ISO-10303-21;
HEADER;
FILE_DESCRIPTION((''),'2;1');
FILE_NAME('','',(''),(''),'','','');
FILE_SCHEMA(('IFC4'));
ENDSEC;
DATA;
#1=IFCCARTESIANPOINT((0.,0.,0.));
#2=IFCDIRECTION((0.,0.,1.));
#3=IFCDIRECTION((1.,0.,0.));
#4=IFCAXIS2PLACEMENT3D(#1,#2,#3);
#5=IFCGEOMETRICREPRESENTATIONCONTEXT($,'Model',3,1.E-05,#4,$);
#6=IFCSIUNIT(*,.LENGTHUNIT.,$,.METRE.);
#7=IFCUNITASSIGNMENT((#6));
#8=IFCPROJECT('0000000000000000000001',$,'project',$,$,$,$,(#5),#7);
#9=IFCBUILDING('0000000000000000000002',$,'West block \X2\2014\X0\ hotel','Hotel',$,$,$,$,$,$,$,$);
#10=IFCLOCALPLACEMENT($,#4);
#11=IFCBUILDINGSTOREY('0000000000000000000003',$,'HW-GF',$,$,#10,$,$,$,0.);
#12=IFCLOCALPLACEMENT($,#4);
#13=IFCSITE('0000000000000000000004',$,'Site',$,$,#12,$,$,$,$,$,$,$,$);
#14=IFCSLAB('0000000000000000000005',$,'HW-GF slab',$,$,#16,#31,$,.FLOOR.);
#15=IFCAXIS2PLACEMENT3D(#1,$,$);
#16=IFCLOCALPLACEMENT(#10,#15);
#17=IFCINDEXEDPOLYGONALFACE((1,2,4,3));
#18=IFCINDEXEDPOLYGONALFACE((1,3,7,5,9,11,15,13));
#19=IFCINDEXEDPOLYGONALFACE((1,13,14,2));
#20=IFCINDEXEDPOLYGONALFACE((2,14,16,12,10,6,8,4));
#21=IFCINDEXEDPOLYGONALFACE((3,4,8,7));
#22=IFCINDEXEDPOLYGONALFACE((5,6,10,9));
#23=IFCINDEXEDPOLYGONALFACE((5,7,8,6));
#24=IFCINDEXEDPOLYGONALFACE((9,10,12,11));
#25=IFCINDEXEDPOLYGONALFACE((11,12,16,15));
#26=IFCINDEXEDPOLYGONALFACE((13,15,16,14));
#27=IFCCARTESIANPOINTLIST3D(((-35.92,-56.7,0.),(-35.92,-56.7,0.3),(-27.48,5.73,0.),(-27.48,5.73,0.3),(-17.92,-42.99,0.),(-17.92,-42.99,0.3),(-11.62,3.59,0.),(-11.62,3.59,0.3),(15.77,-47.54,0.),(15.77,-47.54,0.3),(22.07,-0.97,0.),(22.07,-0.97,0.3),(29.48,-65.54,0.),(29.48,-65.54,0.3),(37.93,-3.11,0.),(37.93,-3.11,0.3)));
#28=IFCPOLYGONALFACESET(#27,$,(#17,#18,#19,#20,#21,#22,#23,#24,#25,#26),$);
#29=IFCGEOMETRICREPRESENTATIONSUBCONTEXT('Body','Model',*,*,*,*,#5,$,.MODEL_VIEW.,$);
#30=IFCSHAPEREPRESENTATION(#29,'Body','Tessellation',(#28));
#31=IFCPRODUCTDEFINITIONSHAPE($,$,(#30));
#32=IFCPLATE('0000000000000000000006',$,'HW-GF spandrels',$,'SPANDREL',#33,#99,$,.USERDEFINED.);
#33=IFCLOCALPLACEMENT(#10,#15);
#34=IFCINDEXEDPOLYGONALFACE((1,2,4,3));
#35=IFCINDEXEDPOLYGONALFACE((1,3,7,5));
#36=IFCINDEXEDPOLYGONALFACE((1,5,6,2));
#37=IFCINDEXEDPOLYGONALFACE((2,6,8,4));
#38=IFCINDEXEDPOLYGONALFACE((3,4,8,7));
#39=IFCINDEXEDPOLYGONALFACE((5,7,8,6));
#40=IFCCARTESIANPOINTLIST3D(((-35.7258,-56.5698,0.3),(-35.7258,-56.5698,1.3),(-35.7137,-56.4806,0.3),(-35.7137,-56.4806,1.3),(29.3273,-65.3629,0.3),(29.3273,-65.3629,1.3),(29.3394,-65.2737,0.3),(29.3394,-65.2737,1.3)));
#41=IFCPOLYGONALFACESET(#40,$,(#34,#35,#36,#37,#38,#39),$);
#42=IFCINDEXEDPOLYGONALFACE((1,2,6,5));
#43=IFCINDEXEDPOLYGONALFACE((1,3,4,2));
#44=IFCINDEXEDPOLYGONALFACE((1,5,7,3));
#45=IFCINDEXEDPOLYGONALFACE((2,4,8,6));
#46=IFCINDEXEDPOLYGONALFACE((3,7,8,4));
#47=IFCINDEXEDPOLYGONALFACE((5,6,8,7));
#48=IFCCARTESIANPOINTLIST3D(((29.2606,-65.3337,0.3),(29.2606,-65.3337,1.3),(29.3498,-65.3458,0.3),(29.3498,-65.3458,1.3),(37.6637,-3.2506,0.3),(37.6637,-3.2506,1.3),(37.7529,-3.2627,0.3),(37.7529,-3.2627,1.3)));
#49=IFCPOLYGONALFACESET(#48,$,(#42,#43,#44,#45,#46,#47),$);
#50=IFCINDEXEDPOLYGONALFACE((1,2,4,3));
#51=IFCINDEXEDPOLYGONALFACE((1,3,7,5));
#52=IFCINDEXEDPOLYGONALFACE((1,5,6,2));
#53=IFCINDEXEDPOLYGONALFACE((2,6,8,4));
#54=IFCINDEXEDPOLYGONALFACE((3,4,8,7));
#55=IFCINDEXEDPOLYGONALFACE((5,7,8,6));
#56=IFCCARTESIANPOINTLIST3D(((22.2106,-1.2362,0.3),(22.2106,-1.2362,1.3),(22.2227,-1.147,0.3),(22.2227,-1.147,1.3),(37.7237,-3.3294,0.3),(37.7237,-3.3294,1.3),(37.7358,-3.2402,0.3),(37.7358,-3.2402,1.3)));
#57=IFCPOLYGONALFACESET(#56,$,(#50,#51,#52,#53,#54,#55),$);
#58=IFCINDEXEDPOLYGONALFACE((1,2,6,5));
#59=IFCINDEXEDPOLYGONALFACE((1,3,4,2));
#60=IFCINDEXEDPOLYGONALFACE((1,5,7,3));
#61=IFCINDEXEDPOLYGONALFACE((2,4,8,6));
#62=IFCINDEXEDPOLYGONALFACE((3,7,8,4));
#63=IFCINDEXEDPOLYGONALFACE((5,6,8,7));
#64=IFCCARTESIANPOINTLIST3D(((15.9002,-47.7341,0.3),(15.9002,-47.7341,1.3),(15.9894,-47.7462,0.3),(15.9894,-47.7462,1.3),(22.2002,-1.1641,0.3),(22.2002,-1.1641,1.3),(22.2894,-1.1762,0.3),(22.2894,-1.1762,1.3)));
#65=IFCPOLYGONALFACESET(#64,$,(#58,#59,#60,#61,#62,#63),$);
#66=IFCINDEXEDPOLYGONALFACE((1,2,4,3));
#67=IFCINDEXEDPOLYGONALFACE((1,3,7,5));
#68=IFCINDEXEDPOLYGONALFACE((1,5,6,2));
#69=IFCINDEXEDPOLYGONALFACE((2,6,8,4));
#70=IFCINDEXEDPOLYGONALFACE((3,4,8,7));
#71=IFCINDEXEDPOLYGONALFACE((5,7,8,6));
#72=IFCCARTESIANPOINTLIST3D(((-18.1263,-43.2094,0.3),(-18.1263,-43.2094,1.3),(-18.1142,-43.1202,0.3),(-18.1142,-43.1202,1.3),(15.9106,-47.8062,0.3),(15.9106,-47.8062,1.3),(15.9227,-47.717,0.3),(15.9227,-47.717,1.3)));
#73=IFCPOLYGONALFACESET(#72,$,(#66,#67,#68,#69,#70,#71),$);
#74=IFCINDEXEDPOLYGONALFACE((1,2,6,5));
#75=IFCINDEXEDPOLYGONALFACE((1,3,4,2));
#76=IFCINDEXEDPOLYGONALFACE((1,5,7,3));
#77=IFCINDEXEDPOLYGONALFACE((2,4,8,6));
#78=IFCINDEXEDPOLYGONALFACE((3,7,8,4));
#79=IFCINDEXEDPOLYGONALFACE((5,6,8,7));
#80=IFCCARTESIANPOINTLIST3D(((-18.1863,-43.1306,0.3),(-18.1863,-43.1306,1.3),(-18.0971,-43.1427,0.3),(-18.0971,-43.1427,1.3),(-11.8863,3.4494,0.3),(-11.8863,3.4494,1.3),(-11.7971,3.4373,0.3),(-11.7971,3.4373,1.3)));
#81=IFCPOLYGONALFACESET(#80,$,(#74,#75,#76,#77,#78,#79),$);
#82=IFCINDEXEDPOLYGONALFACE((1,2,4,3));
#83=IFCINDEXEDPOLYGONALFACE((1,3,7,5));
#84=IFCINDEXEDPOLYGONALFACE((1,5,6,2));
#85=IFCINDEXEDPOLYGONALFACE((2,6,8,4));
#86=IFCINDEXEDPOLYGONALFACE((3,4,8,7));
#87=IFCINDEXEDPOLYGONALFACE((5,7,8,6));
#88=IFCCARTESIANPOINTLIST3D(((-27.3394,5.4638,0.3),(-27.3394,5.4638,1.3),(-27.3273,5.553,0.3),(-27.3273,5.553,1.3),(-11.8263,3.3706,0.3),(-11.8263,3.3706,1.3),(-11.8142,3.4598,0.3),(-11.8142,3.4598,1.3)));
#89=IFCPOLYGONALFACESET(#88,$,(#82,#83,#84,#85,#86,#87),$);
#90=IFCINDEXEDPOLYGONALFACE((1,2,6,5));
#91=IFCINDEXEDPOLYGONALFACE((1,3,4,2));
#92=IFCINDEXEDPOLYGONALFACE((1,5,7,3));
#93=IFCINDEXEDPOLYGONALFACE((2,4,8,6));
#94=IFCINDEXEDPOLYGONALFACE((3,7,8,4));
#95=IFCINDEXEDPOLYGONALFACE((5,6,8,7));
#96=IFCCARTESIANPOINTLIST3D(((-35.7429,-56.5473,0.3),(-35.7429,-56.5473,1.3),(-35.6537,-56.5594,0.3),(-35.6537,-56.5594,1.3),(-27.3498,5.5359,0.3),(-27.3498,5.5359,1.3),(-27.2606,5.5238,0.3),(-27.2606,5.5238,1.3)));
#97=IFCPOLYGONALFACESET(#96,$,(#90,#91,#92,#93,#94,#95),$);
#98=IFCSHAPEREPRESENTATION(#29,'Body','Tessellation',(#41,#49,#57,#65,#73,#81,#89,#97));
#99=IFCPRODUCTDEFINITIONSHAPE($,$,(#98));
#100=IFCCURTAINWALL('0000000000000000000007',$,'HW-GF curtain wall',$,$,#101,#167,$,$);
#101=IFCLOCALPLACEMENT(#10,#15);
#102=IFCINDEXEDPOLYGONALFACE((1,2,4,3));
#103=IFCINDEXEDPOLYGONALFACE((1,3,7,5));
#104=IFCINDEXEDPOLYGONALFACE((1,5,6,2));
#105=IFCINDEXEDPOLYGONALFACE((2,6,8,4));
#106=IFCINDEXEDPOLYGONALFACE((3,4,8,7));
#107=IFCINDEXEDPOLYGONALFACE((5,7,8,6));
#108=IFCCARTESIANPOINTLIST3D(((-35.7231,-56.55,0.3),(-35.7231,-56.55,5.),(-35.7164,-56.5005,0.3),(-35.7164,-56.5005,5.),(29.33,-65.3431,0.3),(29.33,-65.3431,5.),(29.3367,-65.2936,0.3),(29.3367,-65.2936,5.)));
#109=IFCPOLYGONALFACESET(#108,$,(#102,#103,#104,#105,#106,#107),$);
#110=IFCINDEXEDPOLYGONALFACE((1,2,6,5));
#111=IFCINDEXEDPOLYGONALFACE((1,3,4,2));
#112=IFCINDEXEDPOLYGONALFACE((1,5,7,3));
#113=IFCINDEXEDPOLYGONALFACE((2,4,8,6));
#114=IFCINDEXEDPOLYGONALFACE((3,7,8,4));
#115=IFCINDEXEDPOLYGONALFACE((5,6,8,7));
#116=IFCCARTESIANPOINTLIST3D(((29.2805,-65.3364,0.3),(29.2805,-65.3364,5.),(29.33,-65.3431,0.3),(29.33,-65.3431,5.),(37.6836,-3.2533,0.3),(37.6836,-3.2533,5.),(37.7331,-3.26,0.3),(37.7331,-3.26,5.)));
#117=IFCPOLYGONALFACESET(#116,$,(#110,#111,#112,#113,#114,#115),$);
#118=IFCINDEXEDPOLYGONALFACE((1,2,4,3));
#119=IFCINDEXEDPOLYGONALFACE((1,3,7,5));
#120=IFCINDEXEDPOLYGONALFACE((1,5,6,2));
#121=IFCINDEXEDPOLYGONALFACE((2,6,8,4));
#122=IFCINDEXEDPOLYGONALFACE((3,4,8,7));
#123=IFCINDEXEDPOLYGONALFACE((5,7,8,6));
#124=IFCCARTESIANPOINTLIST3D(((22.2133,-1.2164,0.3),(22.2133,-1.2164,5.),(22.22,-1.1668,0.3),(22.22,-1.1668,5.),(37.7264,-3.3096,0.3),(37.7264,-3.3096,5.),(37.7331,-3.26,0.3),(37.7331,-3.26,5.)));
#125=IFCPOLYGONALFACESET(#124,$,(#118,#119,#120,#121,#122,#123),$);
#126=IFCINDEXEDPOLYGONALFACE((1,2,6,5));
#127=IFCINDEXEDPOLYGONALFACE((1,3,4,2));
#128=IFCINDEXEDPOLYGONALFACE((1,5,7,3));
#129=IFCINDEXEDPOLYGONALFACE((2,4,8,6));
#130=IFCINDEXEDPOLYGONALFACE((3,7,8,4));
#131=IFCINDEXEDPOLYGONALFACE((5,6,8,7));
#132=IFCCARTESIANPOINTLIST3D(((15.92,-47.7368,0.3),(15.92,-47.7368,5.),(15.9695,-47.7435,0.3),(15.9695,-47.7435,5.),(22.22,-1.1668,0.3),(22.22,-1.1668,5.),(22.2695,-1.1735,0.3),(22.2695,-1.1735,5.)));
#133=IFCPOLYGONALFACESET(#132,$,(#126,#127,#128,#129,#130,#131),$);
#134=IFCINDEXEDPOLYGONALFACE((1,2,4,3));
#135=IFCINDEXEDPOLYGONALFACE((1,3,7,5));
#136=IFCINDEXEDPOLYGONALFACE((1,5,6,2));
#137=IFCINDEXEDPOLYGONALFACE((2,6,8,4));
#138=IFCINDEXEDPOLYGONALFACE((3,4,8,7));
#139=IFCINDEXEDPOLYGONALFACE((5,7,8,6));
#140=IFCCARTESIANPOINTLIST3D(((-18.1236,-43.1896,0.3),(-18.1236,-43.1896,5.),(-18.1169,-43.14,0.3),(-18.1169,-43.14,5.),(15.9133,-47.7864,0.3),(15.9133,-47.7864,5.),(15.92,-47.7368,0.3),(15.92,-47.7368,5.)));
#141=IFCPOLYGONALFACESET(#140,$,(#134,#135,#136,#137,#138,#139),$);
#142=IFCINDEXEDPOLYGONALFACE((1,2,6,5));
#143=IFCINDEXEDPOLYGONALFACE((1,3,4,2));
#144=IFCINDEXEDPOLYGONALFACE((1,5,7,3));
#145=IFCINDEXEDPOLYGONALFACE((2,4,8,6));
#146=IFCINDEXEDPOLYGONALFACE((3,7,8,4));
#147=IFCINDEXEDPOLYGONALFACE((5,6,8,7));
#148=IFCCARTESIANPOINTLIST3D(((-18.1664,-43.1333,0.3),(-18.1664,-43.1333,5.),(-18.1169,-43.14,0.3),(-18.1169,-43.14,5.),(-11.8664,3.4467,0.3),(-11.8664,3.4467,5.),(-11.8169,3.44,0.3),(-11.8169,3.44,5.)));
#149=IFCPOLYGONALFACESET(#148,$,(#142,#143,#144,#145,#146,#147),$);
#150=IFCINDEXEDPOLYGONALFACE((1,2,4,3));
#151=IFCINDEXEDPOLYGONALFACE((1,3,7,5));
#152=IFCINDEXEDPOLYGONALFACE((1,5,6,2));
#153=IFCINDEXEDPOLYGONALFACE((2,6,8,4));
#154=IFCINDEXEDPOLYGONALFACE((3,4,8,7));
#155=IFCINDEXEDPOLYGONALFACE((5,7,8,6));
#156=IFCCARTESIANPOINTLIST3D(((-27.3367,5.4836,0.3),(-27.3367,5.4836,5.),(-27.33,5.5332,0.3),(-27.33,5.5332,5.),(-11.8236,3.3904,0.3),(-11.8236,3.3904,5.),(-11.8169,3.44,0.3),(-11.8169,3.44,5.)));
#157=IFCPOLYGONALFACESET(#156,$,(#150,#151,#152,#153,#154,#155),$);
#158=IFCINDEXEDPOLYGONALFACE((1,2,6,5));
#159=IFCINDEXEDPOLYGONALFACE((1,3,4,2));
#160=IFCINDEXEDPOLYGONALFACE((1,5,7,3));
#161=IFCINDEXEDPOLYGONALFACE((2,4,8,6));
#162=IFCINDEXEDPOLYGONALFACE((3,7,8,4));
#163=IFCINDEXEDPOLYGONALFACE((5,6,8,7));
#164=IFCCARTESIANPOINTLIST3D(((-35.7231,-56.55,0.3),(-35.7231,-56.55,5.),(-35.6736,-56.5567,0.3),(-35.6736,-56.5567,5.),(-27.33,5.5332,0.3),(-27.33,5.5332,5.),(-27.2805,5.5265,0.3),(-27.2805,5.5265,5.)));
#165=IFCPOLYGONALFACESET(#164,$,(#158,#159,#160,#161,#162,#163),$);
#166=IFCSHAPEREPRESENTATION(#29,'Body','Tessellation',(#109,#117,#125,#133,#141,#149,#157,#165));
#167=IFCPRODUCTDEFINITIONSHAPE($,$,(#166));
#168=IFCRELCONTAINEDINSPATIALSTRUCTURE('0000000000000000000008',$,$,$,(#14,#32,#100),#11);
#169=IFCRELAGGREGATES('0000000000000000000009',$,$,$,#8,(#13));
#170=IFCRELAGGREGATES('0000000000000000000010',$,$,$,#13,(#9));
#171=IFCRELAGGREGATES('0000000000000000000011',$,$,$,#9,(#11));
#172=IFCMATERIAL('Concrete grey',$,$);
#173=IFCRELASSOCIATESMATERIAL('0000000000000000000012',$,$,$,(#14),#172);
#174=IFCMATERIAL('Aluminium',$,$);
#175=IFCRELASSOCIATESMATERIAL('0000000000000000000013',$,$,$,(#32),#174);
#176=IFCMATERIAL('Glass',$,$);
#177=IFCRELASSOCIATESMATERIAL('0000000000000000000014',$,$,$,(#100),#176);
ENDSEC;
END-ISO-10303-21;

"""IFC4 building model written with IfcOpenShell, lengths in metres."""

from ifc_helpers import new_model, si_unit, frame, origin_with_axes, place, context, subcontext, project, spatial, polyline, outline, extrude, material, element, save


model = new_model("IFC4")

# Units and contexts
model_context = context("Model", 3, precision=1e-05, world=origin_with_axes())
body_context = subcontext(model_context, "Body", "Model", "MODEL_VIEW")
ifc_project = project(units=[si_unit("LENGTHUNIT", "METRE")], contexts=[model_context])

# Site, building, storey
site_placement = place(None, origin_with_axes())
site = spatial("IfcSite", under=ifc_project, at=site_placement, Name="Site")
building = spatial("IfcBuilding", under=site, Name="West block — hotel", Description="Hotel")
storey_placement = place(None, origin_with_axes())
storey = spatial("IfcBuildingStorey", under=building, at=storey_placement, Name="HW-GF", Elevation=0.0)

# Shared definitions
ifc_material_1 = material(Name="Aluminium")

# Slab
ifc_material_2 = material(Name="Concrete grey")
slab_placement = place(storey_placement, origin_with_axes())
element("IfcSlab", 1, at=slab_placement, inside=storey, material=ifc_material_2, Name="HW-GF slab", PredefinedType="FLOOR", context=body_context, shape_type="SweptSolid", body=[
    extrude(outline(polyline([(-35.92, -56.7), (29.48, -65.54), (37.93, -3.11), (22.07, -0.97), (15.77, -47.54), (-17.92, -42.99), (-11.62, 3.59), (-27.48, 5.73), (-35.92, -56.7)])), origin_with_axes(), (0.0, 0.0, 1.0), 0.3),
])

# Plate
plate_placement = place(storey_placement, origin_with_axes())
element("IfcPlate", 2, at=plate_placement, inside=storey, material=ifc_material_1, Name="HW-GF spandrels", ObjectType="SPANDREL", PredefinedType="USERDEFINED", context=body_context, shape_type="SweptSolid", body=[
    extrude(outline(polyline([(-35.7258, -56.5698), (29.3273, -65.3629), (29.3394, -65.2737), (-35.7137, -56.4806), (-35.7258, -56.5698)])), frame((0.0, 0.0, 0.3), z_axis=(0.0, 0.0, 1.0), x_axis=(1.0, 0.0, 0.0)), (0.0, 0.0, 1.0), 1.0),
    extrude(outline(polyline([(29.3498, -65.3458), (37.7529, -3.2627), (37.6637, -3.2506), (29.2606, -65.3337), (29.3498, -65.3458)])), frame((0.0, 0.0, 0.3), z_axis=(0.0, 0.0, 1.0), x_axis=(1.0, 0.0, 0.0)), (0.0, 0.0, 1.0), 1.0),
    extrude(outline(polyline([(37.7358, -3.2402), (22.2227, -1.147), (22.2106, -1.2362), (37.7237, -3.3294), (37.7358, -3.2402)])), frame((0.0, 0.0, 0.3), z_axis=(0.0, 0.0, 1.0), x_axis=(1.0, 0.0, 0.0)), (0.0, 0.0, 1.0), 1.0),
    extrude(outline(polyline([(22.2002, -1.1641), (15.9002, -47.7341), (15.9894, -47.7462), (22.2894, -1.1762), (22.2002, -1.1641)])), frame((0.0, 0.0, 0.3), z_axis=(0.0, 0.0, 1.0), x_axis=(1.0, 0.0, 0.0)), (0.0, 0.0, 1.0), 1.0),
    extrude(outline(polyline([(15.9227, -47.717), (-18.1142, -43.1202), (-18.1263, -43.2094), (15.9106, -47.8062), (15.9227, -47.717)])), frame((0.0, 0.0, 0.3), z_axis=(0.0, 0.0, 1.0), x_axis=(1.0, 0.0, 0.0)), (0.0, 0.0, 1.0), 1.0),
    extrude(outline(polyline([(-18.0971, -43.1427), (-11.7971, 3.4373), (-11.8863, 3.4494), (-18.1863, -43.1306), (-18.0971, -43.1427)])), frame((0.0, 0.0, 0.3), z_axis=(0.0, 0.0, 1.0), x_axis=(1.0, 0.0, 0.0)), (0.0, 0.0, 1.0), 1.0),
    extrude(outline(polyline([(-11.8142, 3.4598), (-27.3273, 5.553), (-27.3394, 5.4638), (-11.8263, 3.3706), (-11.8142, 3.4598)])), frame((0.0, 0.0, 0.3), z_axis=(0.0, 0.0, 1.0), x_axis=(1.0, 0.0, 0.0)), (0.0, 0.0, 1.0), 1.0),
    extrude(outline(polyline([(-27.3498, 5.5359), (-35.7429, -56.5473), (-35.6537, -56.5594), (-27.2606, 5.5238), (-27.3498, 5.5359)])), frame((0.0, 0.0, 0.3), z_axis=(0.0, 0.0, 1.0), x_axis=(1.0, 0.0, 0.0)), (0.0, 0.0, 1.0), 1.0),
])

# Curtain wall
ifc_material_3 = material(Name="Glass")
curtain_wall_placement = place(storey_placement, origin_with_axes())
element("IfcCurtainWall", 3, at=curtain_wall_placement, inside=storey, material=ifc_material_3, Name="HW-GF curtain wall", context=body_context, shape_type="SweptSolid", body=[
    extrude(outline(polyline([(-35.7231, -56.55), (29.33, -65.3431), (29.3367, -65.2936), (-35.7164, -56.5005), (-35.7231, -56.55)])), frame((0.0, 0.0, 0.3), z_axis=(0.0, 0.0, 1.0), x_axis=(1.0, 0.0, 0.0)), (0.0, 0.0, 1.0), 4.7),
    extrude(outline(polyline([(29.33, -65.3431), (37.7331, -3.26), (37.6836, -3.2533), (29.2805, -65.3364), (29.33, -65.3431)])), frame((0.0, 0.0, 0.3), z_axis=(0.0, 0.0, 1.0), x_axis=(1.0, 0.0, 0.0)), (0.0, 0.0, 1.0), 4.7),
    extrude(outline(polyline([(37.7331, -3.26), (22.22, -1.1668), (22.2133, -1.2164), (37.7264, -3.3096), (37.7331, -3.26)])), frame((0.0, 0.0, 0.3), z_axis=(0.0, 0.0, 1.0), x_axis=(1.0, 0.0, 0.0)), (0.0, 0.0, 1.0), 4.7),
    extrude(outline(polyline([(22.22, -1.1668), (15.92, -47.7368), (15.9695, -47.7435), (22.2695, -1.1735), (22.22, -1.1668)])), frame((0.0, 0.0, 0.3), z_axis=(0.0, 0.0, 1.0), x_axis=(1.0, 0.0, 0.0)), (0.0, 0.0, 1.0), 4.7),
    extrude(outline(polyline([(15.92, -47.7368), (-18.1169, -43.14), (-18.1236, -43.1896), (15.9133, -47.7864), (15.92, -47.7368)])), frame((0.0, 0.0, 0.3), z_axis=(0.0, 0.0, 1.0), x_axis=(1.0, 0.0, 0.0)), (0.0, 0.0, 1.0), 4.7),
    extrude(outline(polyline([(-18.1169, -43.14), (-11.8169, 3.44), (-11.8664, 3.4467), (-18.1664, -43.1333), (-18.1169, -43.14)])), frame((0.0, 0.0, 0.3), z_axis=(0.0, 0.0, 1.0), x_axis=(1.0, 0.0, 0.0)), (0.0, 0.0, 1.0), 4.7),
    extrude(outline(polyline([(-11.8169, 3.44), (-27.33, 5.5332), (-27.3367, 5.4836), (-11.8236, 3.3904), (-11.8169, 3.44)])), frame((0.0, 0.0, 0.3), z_axis=(0.0, 0.0, 1.0), x_axis=(1.0, 0.0, 0.0)), (0.0, 0.0, 1.0), 4.7),
    extrude(outline(polyline([(-27.33, 5.5332), (-35.7231, -56.55), (-35.6736, -56.5567), (-27.2805, 5.5265), (-27.33, 5.5332)])), frame((0.0, 0.0, 0.3), z_axis=(0.0, 0.0, 1.0), x_axis=(1.0, 0.0, 0.0)), (0.0, 0.0, 1.0), 4.7),
])

save(model, "model.ifc")
